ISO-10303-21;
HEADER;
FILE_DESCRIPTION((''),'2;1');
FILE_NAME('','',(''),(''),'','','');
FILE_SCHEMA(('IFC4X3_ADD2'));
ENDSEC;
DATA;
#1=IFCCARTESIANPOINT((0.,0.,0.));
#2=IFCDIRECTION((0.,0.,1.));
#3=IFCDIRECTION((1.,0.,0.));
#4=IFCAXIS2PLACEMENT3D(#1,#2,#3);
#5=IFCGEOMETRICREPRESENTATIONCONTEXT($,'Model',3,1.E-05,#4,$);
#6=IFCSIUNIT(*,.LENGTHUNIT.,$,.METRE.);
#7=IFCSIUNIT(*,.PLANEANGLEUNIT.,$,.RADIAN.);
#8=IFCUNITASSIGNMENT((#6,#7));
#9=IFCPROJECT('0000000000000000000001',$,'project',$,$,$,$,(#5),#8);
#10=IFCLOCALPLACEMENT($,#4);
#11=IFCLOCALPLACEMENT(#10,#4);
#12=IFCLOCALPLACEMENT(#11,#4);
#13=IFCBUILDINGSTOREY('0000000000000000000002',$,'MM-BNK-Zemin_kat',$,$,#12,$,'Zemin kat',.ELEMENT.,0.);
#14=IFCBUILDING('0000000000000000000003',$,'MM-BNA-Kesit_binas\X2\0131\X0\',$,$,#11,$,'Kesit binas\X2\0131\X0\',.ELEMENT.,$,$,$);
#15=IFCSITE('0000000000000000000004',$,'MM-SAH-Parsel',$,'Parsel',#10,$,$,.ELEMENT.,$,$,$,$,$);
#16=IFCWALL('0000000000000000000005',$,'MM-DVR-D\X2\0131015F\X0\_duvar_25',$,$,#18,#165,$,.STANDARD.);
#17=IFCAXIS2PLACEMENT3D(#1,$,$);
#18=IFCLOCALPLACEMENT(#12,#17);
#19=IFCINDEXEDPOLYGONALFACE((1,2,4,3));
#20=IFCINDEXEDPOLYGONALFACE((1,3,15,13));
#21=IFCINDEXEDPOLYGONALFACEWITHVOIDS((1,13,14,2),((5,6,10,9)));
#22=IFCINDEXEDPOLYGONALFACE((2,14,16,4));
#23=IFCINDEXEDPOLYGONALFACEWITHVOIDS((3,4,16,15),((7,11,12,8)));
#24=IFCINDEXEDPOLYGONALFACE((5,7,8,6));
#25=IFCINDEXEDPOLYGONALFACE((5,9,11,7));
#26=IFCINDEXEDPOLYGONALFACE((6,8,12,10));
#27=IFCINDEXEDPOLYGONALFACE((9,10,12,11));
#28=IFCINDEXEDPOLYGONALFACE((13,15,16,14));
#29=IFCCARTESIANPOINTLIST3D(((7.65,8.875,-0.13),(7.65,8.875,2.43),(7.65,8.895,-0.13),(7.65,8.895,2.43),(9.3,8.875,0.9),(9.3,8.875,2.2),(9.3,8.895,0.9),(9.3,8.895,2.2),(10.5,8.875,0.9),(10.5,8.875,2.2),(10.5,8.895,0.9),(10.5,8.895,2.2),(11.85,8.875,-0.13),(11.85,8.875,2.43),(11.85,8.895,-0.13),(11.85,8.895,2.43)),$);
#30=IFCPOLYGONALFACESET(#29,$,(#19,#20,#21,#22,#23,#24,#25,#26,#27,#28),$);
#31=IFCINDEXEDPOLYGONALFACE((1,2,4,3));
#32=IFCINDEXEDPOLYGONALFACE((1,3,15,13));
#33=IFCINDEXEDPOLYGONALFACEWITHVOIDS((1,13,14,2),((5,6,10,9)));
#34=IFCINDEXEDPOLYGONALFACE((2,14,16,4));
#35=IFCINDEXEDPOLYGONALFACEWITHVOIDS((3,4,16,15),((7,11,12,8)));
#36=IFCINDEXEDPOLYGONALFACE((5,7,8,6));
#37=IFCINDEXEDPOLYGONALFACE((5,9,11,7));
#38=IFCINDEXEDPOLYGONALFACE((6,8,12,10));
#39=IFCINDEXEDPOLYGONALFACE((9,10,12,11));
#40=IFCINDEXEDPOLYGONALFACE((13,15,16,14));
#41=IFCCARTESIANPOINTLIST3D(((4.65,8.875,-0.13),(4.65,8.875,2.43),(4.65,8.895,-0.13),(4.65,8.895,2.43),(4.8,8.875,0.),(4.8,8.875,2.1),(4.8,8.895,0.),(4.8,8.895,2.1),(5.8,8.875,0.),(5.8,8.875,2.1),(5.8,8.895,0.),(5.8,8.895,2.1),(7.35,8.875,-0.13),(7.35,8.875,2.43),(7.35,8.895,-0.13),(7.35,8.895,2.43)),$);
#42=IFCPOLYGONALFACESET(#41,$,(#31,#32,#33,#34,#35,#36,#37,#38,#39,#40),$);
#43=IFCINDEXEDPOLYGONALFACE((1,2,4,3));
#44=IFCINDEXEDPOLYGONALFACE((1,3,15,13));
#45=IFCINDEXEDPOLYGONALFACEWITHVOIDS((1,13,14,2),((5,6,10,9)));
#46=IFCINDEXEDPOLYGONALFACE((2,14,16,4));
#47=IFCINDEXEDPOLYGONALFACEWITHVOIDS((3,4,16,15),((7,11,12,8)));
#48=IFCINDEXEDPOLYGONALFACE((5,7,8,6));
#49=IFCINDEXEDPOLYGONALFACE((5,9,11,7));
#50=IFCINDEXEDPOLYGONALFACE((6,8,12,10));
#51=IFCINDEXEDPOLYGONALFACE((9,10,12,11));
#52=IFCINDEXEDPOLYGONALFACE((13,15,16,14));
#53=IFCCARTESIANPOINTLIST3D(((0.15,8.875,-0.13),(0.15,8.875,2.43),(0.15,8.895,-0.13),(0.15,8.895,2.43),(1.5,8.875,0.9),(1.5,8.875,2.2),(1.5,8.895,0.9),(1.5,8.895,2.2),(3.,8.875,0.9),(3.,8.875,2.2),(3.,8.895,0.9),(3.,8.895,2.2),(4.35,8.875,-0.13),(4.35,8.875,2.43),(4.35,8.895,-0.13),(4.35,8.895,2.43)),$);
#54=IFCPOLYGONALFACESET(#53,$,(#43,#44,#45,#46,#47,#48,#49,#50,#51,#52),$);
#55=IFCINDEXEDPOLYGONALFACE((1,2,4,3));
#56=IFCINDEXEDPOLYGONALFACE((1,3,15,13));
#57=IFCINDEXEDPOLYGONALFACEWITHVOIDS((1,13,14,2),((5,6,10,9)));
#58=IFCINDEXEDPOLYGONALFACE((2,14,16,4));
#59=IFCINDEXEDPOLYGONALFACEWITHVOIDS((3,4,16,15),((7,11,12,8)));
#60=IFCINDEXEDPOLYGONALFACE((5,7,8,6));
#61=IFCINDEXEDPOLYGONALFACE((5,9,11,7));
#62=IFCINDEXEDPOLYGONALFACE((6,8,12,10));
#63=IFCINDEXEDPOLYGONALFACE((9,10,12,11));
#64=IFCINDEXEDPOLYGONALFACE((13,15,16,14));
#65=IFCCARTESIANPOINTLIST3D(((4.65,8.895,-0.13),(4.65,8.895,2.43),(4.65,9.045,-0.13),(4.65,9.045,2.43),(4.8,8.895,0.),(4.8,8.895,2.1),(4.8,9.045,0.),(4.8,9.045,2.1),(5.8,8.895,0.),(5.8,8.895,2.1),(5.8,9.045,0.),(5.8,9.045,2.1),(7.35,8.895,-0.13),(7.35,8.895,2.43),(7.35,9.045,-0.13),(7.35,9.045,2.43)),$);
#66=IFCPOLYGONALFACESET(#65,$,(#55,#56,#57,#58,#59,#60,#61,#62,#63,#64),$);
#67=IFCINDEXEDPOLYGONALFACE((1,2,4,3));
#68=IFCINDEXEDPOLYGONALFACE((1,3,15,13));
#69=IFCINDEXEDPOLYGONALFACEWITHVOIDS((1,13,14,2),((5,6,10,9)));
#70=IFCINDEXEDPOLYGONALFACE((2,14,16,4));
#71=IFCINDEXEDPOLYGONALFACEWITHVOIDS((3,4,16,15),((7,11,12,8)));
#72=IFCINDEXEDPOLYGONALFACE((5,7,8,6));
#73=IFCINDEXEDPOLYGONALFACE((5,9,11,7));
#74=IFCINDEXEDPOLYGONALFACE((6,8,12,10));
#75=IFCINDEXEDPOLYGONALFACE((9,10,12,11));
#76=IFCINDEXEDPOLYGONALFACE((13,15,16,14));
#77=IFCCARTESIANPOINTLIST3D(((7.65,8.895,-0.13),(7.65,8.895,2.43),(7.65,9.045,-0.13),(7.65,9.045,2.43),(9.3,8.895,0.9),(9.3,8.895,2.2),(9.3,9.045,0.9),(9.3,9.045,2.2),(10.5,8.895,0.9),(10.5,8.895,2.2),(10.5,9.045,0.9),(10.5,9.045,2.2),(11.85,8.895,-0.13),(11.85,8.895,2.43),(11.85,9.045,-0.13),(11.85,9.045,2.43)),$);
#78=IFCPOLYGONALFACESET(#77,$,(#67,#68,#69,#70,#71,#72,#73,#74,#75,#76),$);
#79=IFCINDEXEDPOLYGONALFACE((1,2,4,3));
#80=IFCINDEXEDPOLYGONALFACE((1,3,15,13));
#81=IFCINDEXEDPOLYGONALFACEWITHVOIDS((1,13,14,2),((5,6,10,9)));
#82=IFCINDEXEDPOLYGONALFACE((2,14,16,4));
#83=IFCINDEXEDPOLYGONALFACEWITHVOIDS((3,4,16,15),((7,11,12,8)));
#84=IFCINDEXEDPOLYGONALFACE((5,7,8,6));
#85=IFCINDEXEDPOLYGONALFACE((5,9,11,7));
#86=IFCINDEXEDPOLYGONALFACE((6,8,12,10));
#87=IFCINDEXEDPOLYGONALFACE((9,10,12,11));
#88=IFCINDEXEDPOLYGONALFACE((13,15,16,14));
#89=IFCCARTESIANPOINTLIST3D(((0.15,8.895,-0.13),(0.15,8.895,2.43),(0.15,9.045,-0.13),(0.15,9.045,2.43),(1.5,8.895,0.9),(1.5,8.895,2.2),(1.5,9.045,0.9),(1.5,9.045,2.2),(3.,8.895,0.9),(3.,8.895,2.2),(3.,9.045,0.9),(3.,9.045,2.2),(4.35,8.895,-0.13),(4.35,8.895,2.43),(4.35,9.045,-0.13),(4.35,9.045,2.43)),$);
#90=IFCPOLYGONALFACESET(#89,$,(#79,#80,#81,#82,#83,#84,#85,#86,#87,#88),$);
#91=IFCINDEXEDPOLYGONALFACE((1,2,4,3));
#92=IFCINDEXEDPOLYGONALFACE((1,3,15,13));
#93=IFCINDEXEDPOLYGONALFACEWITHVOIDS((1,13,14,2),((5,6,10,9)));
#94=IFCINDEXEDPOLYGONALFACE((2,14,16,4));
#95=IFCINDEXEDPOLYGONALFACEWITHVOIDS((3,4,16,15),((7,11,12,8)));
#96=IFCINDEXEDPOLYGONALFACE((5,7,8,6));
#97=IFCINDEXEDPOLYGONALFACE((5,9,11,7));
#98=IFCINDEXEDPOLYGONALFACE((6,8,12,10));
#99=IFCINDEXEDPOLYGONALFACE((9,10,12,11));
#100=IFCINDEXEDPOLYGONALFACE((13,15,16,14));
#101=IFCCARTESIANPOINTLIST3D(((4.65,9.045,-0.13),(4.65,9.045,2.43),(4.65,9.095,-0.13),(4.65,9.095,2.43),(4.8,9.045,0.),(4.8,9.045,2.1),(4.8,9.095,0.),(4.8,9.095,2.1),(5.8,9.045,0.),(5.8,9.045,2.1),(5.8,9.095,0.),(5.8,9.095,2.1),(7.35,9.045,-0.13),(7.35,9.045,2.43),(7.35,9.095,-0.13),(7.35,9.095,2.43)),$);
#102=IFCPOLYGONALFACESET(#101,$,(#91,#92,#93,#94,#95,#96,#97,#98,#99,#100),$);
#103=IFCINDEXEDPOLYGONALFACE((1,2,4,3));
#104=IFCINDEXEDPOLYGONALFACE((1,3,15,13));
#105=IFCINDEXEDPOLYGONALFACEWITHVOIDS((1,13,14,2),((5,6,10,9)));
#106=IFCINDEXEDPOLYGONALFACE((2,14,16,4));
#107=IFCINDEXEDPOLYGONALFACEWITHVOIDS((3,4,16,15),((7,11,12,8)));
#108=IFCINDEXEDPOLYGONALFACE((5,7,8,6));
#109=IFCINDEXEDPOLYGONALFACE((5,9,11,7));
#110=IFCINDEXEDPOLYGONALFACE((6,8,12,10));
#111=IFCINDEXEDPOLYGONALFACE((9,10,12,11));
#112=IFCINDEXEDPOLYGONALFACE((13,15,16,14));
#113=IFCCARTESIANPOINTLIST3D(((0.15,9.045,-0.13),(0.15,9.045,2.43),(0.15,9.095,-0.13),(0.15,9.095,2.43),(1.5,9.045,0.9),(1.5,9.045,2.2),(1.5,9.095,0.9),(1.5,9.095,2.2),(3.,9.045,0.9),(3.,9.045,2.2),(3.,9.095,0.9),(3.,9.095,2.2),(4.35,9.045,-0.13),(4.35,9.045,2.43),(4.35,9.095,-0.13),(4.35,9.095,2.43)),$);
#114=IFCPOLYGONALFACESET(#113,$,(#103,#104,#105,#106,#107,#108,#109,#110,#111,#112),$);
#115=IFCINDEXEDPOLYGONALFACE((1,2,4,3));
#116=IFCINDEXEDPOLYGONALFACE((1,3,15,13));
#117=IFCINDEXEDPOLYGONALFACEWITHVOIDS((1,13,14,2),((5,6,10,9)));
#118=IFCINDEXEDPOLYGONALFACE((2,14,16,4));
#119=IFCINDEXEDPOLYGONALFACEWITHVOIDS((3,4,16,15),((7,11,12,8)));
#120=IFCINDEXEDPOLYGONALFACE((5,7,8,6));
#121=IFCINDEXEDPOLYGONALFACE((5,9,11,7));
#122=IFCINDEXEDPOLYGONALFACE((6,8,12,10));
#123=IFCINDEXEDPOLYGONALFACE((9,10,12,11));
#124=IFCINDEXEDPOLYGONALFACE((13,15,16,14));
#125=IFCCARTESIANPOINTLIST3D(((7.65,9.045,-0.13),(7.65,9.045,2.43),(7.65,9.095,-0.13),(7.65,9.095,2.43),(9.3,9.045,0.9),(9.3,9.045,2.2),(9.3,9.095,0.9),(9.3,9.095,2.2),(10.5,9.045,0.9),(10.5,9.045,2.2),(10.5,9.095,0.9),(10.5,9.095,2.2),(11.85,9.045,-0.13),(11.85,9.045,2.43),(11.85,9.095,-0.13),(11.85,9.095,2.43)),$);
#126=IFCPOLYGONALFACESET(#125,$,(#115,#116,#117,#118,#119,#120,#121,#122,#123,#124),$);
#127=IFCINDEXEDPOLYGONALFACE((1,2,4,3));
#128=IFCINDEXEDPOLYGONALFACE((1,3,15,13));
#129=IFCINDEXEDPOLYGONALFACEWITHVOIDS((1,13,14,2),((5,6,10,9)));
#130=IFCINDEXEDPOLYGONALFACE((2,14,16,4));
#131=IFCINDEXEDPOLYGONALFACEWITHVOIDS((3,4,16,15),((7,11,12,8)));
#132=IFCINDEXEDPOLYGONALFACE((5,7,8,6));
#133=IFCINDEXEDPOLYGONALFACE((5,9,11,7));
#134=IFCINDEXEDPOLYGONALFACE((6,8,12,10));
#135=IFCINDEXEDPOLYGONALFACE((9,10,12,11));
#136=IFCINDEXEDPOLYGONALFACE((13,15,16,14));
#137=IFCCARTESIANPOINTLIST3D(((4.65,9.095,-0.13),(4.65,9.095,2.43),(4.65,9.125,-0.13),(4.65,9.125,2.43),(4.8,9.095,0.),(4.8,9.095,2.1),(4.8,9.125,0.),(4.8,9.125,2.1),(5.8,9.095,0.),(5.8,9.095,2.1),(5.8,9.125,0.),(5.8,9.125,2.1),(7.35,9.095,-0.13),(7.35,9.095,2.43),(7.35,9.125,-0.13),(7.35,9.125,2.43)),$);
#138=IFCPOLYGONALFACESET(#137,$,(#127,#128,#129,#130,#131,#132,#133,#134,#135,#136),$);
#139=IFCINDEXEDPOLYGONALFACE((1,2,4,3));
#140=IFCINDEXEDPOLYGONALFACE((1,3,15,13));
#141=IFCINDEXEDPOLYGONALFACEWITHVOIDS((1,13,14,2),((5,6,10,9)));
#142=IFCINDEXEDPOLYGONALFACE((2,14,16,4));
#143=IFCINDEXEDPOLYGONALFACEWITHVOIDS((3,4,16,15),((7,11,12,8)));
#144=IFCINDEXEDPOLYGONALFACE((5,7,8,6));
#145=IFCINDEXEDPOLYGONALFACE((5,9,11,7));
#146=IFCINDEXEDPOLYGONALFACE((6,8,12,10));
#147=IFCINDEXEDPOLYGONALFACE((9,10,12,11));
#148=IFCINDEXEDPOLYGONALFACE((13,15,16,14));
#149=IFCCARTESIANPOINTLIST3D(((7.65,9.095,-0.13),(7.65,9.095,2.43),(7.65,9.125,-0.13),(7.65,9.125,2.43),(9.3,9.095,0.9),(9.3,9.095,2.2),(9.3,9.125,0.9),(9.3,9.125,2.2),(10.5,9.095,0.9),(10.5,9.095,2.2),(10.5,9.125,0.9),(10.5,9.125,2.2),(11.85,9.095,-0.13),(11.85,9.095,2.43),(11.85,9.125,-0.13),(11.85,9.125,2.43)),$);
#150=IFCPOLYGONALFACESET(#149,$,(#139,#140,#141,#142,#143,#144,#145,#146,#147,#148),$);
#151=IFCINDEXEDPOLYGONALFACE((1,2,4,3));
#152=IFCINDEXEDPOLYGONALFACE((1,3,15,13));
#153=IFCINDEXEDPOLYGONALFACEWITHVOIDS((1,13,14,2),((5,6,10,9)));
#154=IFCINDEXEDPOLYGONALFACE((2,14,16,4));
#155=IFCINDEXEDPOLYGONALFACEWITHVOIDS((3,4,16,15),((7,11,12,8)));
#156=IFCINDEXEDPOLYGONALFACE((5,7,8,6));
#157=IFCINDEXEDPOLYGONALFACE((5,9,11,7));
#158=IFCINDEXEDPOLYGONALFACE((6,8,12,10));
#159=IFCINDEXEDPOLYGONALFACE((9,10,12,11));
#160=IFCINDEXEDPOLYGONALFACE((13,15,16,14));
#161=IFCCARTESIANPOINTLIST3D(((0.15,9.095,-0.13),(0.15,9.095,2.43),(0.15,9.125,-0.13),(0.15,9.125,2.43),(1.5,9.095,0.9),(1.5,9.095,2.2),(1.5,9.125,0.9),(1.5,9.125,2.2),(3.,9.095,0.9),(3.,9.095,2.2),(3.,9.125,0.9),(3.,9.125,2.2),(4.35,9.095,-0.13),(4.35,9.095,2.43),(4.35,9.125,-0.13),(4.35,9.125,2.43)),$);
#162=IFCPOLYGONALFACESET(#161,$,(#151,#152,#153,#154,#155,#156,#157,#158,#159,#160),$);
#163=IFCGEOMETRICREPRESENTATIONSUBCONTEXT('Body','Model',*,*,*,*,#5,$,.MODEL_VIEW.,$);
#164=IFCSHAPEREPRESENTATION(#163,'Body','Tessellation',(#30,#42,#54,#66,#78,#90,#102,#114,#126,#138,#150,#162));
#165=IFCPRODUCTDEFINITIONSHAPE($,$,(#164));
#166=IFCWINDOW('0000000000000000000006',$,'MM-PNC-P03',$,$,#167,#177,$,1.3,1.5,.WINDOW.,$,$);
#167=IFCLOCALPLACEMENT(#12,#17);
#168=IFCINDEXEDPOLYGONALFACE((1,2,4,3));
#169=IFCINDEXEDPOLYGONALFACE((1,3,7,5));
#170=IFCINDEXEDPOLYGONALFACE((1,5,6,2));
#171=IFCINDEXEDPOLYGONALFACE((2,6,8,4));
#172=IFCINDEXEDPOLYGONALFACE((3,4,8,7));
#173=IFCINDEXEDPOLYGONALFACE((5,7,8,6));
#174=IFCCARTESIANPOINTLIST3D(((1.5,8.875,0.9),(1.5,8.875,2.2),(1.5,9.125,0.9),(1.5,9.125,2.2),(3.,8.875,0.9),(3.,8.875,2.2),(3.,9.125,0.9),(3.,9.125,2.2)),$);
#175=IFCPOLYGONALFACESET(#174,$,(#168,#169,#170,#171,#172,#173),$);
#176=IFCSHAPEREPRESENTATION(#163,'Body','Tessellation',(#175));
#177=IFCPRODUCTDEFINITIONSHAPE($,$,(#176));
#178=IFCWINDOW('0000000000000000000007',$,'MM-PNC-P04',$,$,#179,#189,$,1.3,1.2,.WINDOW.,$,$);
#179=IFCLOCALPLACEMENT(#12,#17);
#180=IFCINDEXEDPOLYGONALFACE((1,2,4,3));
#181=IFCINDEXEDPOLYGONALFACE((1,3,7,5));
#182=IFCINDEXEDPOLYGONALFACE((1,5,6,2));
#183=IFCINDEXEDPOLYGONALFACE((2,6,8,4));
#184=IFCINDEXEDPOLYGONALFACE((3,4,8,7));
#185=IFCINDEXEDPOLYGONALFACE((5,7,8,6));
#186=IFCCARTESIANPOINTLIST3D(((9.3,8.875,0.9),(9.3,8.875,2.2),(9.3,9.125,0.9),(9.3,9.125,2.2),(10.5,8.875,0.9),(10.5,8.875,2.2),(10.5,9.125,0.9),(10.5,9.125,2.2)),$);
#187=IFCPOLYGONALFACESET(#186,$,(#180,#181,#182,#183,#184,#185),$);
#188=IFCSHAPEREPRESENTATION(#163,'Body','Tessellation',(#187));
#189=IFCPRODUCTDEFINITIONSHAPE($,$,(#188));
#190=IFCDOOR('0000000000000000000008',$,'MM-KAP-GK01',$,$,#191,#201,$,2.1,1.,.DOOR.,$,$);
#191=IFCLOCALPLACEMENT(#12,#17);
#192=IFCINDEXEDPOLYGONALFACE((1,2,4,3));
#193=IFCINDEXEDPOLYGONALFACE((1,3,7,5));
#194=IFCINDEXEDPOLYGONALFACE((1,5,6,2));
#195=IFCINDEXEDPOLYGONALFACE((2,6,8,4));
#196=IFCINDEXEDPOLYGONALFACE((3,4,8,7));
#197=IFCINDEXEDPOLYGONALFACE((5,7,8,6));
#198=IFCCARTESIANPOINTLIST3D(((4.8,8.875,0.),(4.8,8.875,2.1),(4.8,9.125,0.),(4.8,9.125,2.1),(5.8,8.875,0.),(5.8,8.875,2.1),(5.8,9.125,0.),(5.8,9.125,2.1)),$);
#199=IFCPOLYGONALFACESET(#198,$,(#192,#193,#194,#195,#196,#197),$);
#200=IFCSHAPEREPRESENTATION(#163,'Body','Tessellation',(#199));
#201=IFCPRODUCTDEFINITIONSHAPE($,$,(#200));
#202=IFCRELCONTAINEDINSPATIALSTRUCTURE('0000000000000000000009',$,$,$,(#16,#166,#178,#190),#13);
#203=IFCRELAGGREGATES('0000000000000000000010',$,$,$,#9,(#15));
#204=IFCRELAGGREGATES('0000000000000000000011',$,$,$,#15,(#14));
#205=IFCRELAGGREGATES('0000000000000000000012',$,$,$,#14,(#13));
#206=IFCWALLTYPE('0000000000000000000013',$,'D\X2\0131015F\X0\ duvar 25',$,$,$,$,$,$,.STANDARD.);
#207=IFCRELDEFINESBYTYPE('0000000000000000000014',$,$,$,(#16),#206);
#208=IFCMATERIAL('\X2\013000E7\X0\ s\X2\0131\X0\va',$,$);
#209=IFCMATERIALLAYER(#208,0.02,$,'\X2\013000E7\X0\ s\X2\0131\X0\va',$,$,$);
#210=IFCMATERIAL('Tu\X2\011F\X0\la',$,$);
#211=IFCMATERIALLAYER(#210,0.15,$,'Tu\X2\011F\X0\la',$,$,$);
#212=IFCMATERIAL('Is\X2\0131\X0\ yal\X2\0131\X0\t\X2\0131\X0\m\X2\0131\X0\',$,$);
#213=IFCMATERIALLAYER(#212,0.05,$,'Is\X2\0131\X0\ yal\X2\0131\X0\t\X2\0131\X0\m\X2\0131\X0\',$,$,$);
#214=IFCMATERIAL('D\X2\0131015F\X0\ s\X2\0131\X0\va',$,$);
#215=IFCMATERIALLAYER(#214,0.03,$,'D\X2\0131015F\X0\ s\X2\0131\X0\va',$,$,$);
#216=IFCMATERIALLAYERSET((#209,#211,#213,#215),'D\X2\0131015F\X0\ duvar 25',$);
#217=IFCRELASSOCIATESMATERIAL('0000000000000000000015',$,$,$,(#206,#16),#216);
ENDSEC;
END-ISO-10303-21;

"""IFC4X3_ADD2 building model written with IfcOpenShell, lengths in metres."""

from ifc_helpers import new_model, si_unit, frame, origin, origin_with_axes, place, context, subcontext, project, spatial, polyline, outline, extrude, material, layer, layer_set, type_object, element, fill, save


model = new_model("IFC4X3_ADD2")

# Units and contexts
model_context = context("Model", 3, precision=1e-05, world=origin_with_axes())
body_context = subcontext(model_context, "Body", "Model", "MODEL_VIEW")
ifc_project = project(units=[si_unit("LENGTHUNIT", "METRE"), si_unit("PLANEANGLEUNIT", "RADIAN")], contexts=[model_context])

# Site, building, storey
site_placement = place(None, origin_with_axes())
site = spatial("IfcSite", under=ifc_project, at=site_placement, Name="MM-SAH-Parsel", ObjectType="Parsel", CompositionType="ELEMENT")
building_placement = place(site_placement, origin_with_axes())
building = spatial("IfcBuilding", under=site, at=building_placement, Name="MM-BNA-Kesit_binası", LongName="Kesit binası", CompositionType="ELEMENT")
storey_placement = place(building_placement, origin_with_axes())
storey = spatial("IfcBuildingStorey", under=building, at=storey_placement, Name="MM-BNK-Zemin_kat", LongName="Zemin kat", CompositionType="ELEMENT", Elevation=0.0)

# Shared definitions
ifc_material_1 = material(Name="İç sıva")
ifc_layer_1 = layer(ifc_material_1, 0.02, Name="İç sıva")
ifc_material_2 = material(Name="Tuğla")
ifc_layer_2 = layer(ifc_material_2, 0.15, Name="Tuğla")
ifc_material_3 = material(Name="Isı yalıtımı")
ifc_layer_3 = layer(ifc_material_3, 0.05, Name="Isı yalıtımı")
ifc_material_4 = material(Name="Dış sıva")
ifc_layer_4 = layer(ifc_material_4, 0.03, Name="Dış sıva")
ifc_layer_set_1 = layer_set([ifc_layer_1, ifc_layer_2, ifc_layer_3, ifc_layer_4], Name="Dış duvar 25")
wall_type_1 = type_object("IfcWallType", Name="Dış duvar 25", PredefinedType="STANDARD", material=ifc_layer_set_1)

# Wall, openings, windows, door
wall_1_placement = place(storey_placement, origin_with_axes())
wall_1 = element("IfcWall", 1, at=wall_1_placement, inside=storey, type_object=wall_type_1, material=ifc_layer_set_1, Name="MM-DVR-Dış_duvar_25", PredefinedType="STANDARD", context=body_context, shape_type="SweptSolid", body=[
    extrude(outline(polyline([(11.85, 8.895), (7.65, 8.895), (7.65, 8.875), (11.85, 8.875), (11.85, 8.895)])), frame((0.0, 0.0, -0.13)), (0.0, 0.0, 1.0), 2.56),
    extrude(outline(polyline([(7.35, 8.895), (4.65, 8.895), (4.65, 8.875), (7.35, 8.875), (7.35, 8.895)])), frame((0.0, 0.0, -0.13)), (0.0, 0.0, 1.0), 2.56),
    extrude(outline(polyline([(4.35, 8.895), (0.15, 8.895), (0.15, 8.875), (4.35, 8.875), (4.35, 8.895)])), frame((0.0, 0.0, -0.13)), (0.0, 0.0, 1.0), 2.56),
    extrude(outline(polyline([(7.35, 9.045), (4.65, 9.045), (4.65, 8.895), (7.35, 8.895), (7.35, 9.045)])), frame((0.0, 0.0, -0.13)), (0.0, 0.0, 1.0), 2.56),
    extrude(outline(polyline([(11.85, 9.045), (7.65, 9.045), (7.65, 8.895), (11.85, 8.895), (11.85, 9.045)])), frame((0.0, 0.0, -0.13)), (0.0, 0.0, 1.0), 2.56),
    extrude(outline(polyline([(4.35, 9.045), (0.15, 9.045), (0.15, 8.895), (4.35, 8.895), (4.35, 9.045)])), frame((0.0, 0.0, -0.13)), (0.0, 0.0, 1.0), 2.56),
    extrude(outline(polyline([(7.35, 9.095), (4.65, 9.095), (4.65, 9.045), (7.35, 9.045), (7.35, 9.095)])), frame((0.0, 0.0, -0.13)), (0.0, 0.0, 1.0), 2.56),
    extrude(outline(polyline([(4.35, 9.095), (0.15, 9.095), (0.15, 9.045), (4.35, 9.045), (4.35, 9.095)])), frame((0.0, 0.0, -0.13)), (0.0, 0.0, 1.0), 2.56),
    extrude(outline(polyline([(11.85, 9.095), (7.65, 9.095), (7.65, 9.045), (11.85, 9.045), (11.85, 9.095)])), frame((0.0, 0.0, -0.13)), (0.0, 0.0, 1.0), 2.56),
    extrude(outline(polyline([(7.35, 9.125), (4.65, 9.125), (4.65, 9.095), (7.35, 9.095), (7.35, 9.125)])), frame((0.0, 0.0, -0.13)), (0.0, 0.0, 1.0), 2.56),
    extrude(outline(polyline([(11.85, 9.125), (7.65, 9.125), (7.65, 9.095), (11.85, 9.095), (11.85, 9.125)])), frame((0.0, 0.0, -0.13)), (0.0, 0.0, 1.0), 2.56),
    extrude(outline(polyline([(4.35, 9.125), (0.15, 9.125), (0.15, 9.095), (4.35, 9.095), (4.35, 9.125)])), frame((0.0, 0.0, -0.13)), (0.0, 0.0, 1.0), 2.56),
])
opening_1_placement = place(storey_placement, origin_with_axes())
opening_1 = element("IfcOpeningElement", 2, at=opening_1_placement, cuts=wall_1, PredefinedType="OPENING", context=body_context, shape_type="SweptSolid", body=[
    extrude(outline(polyline([(3.0, 8.875), (1.5, 8.875), (1.5, 9.125), (3.0, 9.125), (3.0, 8.875)])), frame((0.0, 0.0, 0.9)), (0.0, 0.0, 1.0), 1.3),
])
opening_2_placement = place(storey_placement, origin_with_axes())
opening_2 = element("IfcOpeningElement", 3, at=opening_2_placement, cuts=wall_1, PredefinedType="OPENING", context=body_context, shape_type="SweptSolid", body=[
    extrude(outline(polyline([(10.5, 8.875), (9.3, 8.875), (9.3, 9.125), (10.5, 9.125), (10.5, 8.875)])), frame((0.0, 0.0, 0.9)), (0.0, 0.0, 1.0), 1.3),
])
opening_3_placement = place(storey_placement, origin_with_axes())
opening_3 = element("IfcOpeningElement", 4, at=opening_3_placement, cuts=wall_1, PredefinedType="OPENING", context=body_context, shape_type="SweptSolid", body=[
    extrude(outline(polyline([(5.8, 8.875), (4.8, 8.875), (4.8, 9.125), (5.8, 9.125), (5.8, 8.875)])), origin(), (0.0, 0.0, 1.0), 2.1),
])
window_1_placement = place(storey_placement, origin_with_axes())
window_1 = element("IfcWindow", 5, at=window_1_placement, inside=storey, Name="MM-PNC-P03", OverallHeight=1.3, OverallWidth=1.5, PredefinedType="WINDOW", context=body_context, shape_type="SweptSolid", body=[
    extrude(outline(polyline([(3.0, 8.875), (1.5, 8.875), (1.5, 9.125), (3.0, 9.125), (3.0, 8.875)])), frame((0.0, 0.0, 0.9)), (0.0, 0.0, 1.0), 1.3),
])
fill(opening_1, window_1)
window_2_placement = place(storey_placement, origin_with_axes())
window_2 = element("IfcWindow", 6, at=window_2_placement, inside=storey, Name="MM-PNC-P04", OverallHeight=1.3, OverallWidth=1.2, PredefinedType="WINDOW", context=body_context, shape_type="SweptSolid", body=[
    extrude(outline(polyline([(10.5, 8.875), (9.3, 8.875), (9.3, 9.125), (10.5, 9.125), (10.5, 8.875)])), frame((0.0, 0.0, 0.9)), (0.0, 0.0, 1.0), 1.3),
])
fill(opening_2, window_2)
door_1_placement = place(storey_placement, origin_with_axes())
door_1 = element("IfcDoor", 7, at=door_1_placement, inside=storey, Name="MM-KAP-GK01", OverallHeight=2.1, OverallWidth=1.0, PredefinedType="DOOR", context=body_context, shape_type="SweptSolid", body=[
    extrude(outline(polyline([(5.8, 8.875), (4.8, 8.875), (4.8, 9.125), (5.8, 9.125), (5.8, 8.875)])), origin(), (0.0, 0.0, 1.0), 2.1),
])
fill(opening_3, door_1)

save(model, "model.ifc")
